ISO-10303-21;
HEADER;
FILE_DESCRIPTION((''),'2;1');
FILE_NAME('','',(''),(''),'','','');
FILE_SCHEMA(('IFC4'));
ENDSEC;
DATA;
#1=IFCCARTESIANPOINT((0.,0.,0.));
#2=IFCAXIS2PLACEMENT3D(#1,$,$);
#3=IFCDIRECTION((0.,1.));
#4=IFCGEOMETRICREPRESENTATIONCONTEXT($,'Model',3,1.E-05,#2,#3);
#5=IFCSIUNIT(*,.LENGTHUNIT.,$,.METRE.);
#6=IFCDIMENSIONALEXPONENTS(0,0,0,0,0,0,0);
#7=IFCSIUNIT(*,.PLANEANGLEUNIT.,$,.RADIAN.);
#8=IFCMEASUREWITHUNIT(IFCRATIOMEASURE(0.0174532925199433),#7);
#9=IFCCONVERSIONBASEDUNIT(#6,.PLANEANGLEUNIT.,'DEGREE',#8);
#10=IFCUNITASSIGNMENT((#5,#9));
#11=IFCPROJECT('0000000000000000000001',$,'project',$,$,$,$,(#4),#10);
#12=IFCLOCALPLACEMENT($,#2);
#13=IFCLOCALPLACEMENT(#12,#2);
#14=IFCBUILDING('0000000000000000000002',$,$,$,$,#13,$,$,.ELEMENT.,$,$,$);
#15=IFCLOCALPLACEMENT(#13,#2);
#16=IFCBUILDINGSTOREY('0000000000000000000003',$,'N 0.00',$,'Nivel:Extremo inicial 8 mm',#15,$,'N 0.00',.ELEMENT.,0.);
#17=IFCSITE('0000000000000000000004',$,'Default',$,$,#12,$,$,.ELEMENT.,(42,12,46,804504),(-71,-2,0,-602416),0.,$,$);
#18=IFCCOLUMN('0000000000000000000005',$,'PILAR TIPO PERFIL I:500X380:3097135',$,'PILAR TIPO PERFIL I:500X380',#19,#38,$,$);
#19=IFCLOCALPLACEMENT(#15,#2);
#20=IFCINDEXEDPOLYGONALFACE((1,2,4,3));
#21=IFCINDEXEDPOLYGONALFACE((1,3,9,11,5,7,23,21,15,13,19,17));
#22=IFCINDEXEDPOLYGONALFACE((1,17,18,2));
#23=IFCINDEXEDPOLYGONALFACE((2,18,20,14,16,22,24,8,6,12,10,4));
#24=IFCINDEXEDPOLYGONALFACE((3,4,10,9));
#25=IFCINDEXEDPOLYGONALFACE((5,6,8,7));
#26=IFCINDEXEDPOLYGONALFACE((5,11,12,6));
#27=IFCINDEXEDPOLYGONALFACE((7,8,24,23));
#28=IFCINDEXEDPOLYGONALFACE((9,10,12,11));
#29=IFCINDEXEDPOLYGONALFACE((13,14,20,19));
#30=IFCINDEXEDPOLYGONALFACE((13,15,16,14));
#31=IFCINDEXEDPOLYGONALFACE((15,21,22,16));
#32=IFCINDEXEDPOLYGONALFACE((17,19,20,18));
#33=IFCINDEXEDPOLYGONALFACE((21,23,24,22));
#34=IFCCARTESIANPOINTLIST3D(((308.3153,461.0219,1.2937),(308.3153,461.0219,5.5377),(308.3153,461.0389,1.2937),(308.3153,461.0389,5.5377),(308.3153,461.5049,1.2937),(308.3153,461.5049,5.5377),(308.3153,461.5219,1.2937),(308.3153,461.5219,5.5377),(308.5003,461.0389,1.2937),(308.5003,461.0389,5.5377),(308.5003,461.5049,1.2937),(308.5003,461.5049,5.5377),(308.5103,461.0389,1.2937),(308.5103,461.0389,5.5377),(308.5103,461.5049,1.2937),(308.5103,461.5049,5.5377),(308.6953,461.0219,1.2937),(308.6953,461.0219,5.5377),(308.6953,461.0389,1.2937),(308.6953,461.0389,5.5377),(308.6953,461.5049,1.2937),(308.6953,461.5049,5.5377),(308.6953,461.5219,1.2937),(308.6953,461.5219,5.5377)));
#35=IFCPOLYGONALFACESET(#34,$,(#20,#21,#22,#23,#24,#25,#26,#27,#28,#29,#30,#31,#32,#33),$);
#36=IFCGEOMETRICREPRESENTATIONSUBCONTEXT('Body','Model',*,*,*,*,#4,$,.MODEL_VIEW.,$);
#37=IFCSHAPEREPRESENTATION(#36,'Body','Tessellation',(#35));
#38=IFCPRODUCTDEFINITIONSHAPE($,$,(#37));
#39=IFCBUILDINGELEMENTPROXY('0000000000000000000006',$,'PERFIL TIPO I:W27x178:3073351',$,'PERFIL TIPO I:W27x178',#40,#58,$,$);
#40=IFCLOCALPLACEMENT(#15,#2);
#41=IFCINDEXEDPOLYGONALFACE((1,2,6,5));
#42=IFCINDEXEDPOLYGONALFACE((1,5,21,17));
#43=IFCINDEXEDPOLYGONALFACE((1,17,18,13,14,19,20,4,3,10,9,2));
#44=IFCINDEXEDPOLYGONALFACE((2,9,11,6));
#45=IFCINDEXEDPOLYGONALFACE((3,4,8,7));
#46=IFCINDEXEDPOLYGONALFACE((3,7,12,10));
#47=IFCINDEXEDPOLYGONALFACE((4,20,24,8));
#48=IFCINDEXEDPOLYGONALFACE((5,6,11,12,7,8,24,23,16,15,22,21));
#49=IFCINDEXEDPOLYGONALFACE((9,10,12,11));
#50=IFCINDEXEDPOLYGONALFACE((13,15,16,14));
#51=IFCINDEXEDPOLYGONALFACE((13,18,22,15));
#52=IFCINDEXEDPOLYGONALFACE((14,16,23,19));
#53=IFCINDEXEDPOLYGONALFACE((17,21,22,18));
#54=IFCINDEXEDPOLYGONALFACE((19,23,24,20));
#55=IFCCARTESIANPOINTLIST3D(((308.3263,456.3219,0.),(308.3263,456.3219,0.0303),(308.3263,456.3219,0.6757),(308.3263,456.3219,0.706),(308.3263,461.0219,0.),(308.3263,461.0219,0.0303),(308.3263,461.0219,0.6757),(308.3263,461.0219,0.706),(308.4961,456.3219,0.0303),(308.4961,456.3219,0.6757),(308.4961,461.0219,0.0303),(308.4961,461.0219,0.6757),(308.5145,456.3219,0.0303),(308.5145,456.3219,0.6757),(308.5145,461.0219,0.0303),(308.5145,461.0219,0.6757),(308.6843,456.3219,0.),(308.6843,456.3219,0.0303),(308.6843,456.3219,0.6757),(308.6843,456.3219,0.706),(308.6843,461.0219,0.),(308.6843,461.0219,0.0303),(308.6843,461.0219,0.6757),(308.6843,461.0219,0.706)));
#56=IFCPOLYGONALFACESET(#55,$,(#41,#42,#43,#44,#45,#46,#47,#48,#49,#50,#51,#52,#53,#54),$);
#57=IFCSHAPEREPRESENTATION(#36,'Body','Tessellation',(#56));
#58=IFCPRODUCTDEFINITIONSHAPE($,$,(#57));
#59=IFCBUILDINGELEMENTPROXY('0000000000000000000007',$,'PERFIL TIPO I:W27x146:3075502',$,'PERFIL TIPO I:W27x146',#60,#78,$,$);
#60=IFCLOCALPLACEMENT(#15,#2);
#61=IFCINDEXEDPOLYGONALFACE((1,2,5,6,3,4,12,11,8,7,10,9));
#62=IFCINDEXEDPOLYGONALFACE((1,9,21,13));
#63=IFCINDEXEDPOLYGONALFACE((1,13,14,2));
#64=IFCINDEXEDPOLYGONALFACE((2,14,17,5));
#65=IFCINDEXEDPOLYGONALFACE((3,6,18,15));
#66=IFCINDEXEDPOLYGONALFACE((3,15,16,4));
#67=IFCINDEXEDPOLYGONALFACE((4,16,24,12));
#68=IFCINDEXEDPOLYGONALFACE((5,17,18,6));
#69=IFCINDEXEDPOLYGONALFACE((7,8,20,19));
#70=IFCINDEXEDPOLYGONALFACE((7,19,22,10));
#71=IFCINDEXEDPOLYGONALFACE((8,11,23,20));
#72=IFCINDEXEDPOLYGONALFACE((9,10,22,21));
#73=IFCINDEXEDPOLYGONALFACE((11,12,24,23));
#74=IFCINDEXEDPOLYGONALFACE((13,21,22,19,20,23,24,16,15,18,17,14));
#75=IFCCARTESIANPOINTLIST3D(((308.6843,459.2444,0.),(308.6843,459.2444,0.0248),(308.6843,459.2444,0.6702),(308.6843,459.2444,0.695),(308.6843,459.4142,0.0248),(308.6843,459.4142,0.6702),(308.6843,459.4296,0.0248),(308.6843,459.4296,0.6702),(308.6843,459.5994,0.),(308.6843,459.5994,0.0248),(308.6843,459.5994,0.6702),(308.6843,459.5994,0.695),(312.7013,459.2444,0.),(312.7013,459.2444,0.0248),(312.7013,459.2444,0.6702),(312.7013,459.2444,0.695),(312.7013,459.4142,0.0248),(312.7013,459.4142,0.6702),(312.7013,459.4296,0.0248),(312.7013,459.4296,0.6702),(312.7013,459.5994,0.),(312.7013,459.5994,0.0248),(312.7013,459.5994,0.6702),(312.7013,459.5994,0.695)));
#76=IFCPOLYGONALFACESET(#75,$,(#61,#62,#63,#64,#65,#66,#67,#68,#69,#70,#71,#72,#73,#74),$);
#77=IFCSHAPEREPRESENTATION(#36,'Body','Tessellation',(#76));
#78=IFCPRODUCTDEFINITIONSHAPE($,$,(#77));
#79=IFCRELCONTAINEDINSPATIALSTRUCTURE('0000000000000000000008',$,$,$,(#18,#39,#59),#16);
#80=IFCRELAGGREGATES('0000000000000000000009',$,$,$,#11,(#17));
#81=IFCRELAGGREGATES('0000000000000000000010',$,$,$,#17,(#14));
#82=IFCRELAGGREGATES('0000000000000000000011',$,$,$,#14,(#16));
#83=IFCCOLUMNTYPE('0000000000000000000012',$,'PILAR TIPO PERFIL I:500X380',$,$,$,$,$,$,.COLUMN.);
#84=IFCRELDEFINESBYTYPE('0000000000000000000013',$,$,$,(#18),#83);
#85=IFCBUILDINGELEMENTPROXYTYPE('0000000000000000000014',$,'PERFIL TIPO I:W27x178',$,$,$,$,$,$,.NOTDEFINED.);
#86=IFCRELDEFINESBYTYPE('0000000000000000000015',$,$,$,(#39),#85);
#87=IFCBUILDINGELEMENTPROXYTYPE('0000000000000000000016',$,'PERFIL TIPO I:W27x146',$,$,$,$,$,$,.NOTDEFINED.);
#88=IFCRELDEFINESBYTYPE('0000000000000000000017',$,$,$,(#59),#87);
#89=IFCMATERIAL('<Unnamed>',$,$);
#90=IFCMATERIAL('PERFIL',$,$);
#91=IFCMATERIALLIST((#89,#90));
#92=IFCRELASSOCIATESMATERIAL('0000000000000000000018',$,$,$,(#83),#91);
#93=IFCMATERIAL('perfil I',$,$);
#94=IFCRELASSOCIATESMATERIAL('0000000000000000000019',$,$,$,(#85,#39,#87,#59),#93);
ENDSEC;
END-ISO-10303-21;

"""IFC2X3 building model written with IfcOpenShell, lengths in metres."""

from ifc_helpers import new_model, entity, si_unit, converted_unit, direction, frame, frame_2d, origin, place, context, subcontext, project, spatial, polyline, i_section, outline, extrude, source, transform, mapped, material, material_list, type_object, type_shapes, element, save


model = new_model("IFC2X3")

# Units and contexts
model_context = context("Model", 3, precision=1e-05, world=origin(), true_north=direction((0.0, 1.0)))
body_context = subcontext(model_context, "Body", "Model", "MODEL_VIEW")
ifc_project = project(units=[si_unit("LENGTHUNIT", "METRE"), converted_unit("PLANEANGLEUNIT", "DEGREE", entity("IfcRatioMeasure", 0.0174532925199433), si_unit("PLANEANGLEUNIT", "RADIAN"), dimensions=[0, 0, 0, 0, 0, 0, 0])], contexts=[model_context])

# Site, building, storey
site_placement = place(None, origin())
site = spatial("IfcSite", under=ifc_project, at=site_placement, Name="Default", CompositionType="ELEMENT", RefLatitude=(42, 12, 46, 804504), RefLongitude=(-71, -2, 0, -602416), RefElevation=0.0)
building_placement = place(site_placement, origin())
building = spatial("IfcBuilding", under=site, at=building_placement, CompositionType="ELEMENT")
storey_placement = place(building_placement, origin())
storey = spatial("IfcBuildingStorey", under=building, at=storey_placement, Name="N 0.00", ObjectType="Nivel:Extremo inicial 8 mm", LongName="N 0.00", CompositionType="ELEMENT", Elevation=0.0)

# Column
ifc_material_1 = material(Name="<Unnamed>")
ifc_material_2 = material(Name="PERFIL")
ifc_material_list_1 = material_list([ifc_material_1, ifc_material_2])
column_type = type_object("IfcColumnType", Name="PILAR TIPO PERFIL I:500X380", PredefinedType="COLUMN", material=ifc_material_list_1)
shared_shape_1 = source(origin(), body_context, "Body", "SweptSolid", [
    extrude(i_section(OverallWidth=0.38, OverallDepth=0.5, WebThickness=0.01, FlangeThickness=0.017, at=frame_2d((0.0, 0.0), x_axis=(1.0, 0.0))), frame((0.0, 0.0, 1.2937), z_axis=(0.0, 0.0, 1.0), x_axis=(0.0, -1.0, 0.0)), (0.0, 0.0, 1.0), 4.244),
])
type_shapes(column_type, [shared_shape_1])
column_placement = place(storey_placement, frame((308.5053, 461.2719, 0.0), z_axis=(0.0, 0.0, 1.0), x_axis=(0.0, -1.0, 0.0)))
element("IfcColumn", 1, at=column_placement, inside=storey, type_object=column_type, Name="PILAR TIPO PERFIL I:500X380:3097135", ObjectType="PILAR TIPO PERFIL I:500X380", context=body_context, shape_type="MappedRepresentation", body=[
    mapped(shared_shape_1, transform((0.0, 0.0, 0.0), scale=1.0)),
])

# Building element proxies
ifc_material_3 = material(Name="perfil I")
building_element_proxy_type_1 = type_object("IfcBuildingElementProxyType", Name="PERFIL TIPO I:W27x178", PredefinedType="NOTDEFINED", material=ifc_material_3)
shared_shape_2 = source(origin(), body_context, "Body", "SweptSolid", [
    extrude(outline(polyline([(0.3227, -0.179), (0.353, -0.179), (0.353, 0.179), (0.3227, 0.179), (0.3227, 0.0092), (-0.3227, 0.0092), (-0.3227, 0.179), (-0.353, 0.179), (-0.353, -0.179), (-0.3227, -0.179), (-0.3227, -0.0092), (0.3227, -0.0092), (0.3227, -0.179)])), frame((0.0, 0.0, 0.353), z_axis=(1.0, 0.0, 0.0), x_axis=(0.0, 0.0, 1.0)), (0.0, 0.0, 1.0), 4.7),
])
type_shapes(building_element_proxy_type_1, [shared_shape_2])
proxy_1_placement = place(storey_placement, frame((308.5053, 461.0219, 0.0), z_axis=(0.0, 0.0, 1.0), x_axis=(0.0, -1.0, 0.0)))
element("IfcBuildingElementProxy", 2, at=proxy_1_placement, inside=storey, type_object=building_element_proxy_type_1, material=ifc_material_3, Name="PERFIL TIPO I:W27x178:3073351", ObjectType="PERFIL TIPO I:W27x178", context=body_context, shape_type="MappedRepresentation", body=[
    mapped(shared_shape_2, transform((0.0, 0.0, 0.0), scale=1.0)),
])
building_element_proxy_type_2 = type_object("IfcBuildingElementProxyType", Name="PERFIL TIPO I:W27x146", PredefinedType="NOTDEFINED", material=ifc_material_3)
shared_shape_3 = source(origin(), body_context, "Body", "SweptSolid", [
    extrude(outline(polyline([(0.3227, -0.1775), (0.3475, -0.1775), (0.3475, 0.1775), (0.3227, 0.1775), (0.3227, 0.0077), (-0.3227, 0.0077), (-0.3227, 0.1775), (-0.3475, 0.1775), (-0.3475, -0.1775), (-0.3227, -0.1775), (-0.3227, -0.0077), (0.3227, -0.0077), (0.3227, -0.1775)])), frame((0.0, 0.0, 0.3475), z_axis=(1.0, 0.0, 0.0), x_axis=(0.0, 0.0, 1.0)), (0.0, 0.0, 1.0), 4.017),
])
type_shapes(building_element_proxy_type_2, [shared_shape_3])
proxy_2_placement = place(storey_placement, frame((308.6843, 459.4219, 0.0)))
element("IfcBuildingElementProxy", 3, at=proxy_2_placement, inside=storey, type_object=building_element_proxy_type_2, material=ifc_material_3, Name="PERFIL TIPO I:W27x146:3075502", ObjectType="PERFIL TIPO I:W27x146", context=body_context, shape_type="MappedRepresentation", body=[
    mapped(shared_shape_3, transform((0.0, 0.0, 0.0), scale=1.0)),
])

save(model, "model.ifc")
